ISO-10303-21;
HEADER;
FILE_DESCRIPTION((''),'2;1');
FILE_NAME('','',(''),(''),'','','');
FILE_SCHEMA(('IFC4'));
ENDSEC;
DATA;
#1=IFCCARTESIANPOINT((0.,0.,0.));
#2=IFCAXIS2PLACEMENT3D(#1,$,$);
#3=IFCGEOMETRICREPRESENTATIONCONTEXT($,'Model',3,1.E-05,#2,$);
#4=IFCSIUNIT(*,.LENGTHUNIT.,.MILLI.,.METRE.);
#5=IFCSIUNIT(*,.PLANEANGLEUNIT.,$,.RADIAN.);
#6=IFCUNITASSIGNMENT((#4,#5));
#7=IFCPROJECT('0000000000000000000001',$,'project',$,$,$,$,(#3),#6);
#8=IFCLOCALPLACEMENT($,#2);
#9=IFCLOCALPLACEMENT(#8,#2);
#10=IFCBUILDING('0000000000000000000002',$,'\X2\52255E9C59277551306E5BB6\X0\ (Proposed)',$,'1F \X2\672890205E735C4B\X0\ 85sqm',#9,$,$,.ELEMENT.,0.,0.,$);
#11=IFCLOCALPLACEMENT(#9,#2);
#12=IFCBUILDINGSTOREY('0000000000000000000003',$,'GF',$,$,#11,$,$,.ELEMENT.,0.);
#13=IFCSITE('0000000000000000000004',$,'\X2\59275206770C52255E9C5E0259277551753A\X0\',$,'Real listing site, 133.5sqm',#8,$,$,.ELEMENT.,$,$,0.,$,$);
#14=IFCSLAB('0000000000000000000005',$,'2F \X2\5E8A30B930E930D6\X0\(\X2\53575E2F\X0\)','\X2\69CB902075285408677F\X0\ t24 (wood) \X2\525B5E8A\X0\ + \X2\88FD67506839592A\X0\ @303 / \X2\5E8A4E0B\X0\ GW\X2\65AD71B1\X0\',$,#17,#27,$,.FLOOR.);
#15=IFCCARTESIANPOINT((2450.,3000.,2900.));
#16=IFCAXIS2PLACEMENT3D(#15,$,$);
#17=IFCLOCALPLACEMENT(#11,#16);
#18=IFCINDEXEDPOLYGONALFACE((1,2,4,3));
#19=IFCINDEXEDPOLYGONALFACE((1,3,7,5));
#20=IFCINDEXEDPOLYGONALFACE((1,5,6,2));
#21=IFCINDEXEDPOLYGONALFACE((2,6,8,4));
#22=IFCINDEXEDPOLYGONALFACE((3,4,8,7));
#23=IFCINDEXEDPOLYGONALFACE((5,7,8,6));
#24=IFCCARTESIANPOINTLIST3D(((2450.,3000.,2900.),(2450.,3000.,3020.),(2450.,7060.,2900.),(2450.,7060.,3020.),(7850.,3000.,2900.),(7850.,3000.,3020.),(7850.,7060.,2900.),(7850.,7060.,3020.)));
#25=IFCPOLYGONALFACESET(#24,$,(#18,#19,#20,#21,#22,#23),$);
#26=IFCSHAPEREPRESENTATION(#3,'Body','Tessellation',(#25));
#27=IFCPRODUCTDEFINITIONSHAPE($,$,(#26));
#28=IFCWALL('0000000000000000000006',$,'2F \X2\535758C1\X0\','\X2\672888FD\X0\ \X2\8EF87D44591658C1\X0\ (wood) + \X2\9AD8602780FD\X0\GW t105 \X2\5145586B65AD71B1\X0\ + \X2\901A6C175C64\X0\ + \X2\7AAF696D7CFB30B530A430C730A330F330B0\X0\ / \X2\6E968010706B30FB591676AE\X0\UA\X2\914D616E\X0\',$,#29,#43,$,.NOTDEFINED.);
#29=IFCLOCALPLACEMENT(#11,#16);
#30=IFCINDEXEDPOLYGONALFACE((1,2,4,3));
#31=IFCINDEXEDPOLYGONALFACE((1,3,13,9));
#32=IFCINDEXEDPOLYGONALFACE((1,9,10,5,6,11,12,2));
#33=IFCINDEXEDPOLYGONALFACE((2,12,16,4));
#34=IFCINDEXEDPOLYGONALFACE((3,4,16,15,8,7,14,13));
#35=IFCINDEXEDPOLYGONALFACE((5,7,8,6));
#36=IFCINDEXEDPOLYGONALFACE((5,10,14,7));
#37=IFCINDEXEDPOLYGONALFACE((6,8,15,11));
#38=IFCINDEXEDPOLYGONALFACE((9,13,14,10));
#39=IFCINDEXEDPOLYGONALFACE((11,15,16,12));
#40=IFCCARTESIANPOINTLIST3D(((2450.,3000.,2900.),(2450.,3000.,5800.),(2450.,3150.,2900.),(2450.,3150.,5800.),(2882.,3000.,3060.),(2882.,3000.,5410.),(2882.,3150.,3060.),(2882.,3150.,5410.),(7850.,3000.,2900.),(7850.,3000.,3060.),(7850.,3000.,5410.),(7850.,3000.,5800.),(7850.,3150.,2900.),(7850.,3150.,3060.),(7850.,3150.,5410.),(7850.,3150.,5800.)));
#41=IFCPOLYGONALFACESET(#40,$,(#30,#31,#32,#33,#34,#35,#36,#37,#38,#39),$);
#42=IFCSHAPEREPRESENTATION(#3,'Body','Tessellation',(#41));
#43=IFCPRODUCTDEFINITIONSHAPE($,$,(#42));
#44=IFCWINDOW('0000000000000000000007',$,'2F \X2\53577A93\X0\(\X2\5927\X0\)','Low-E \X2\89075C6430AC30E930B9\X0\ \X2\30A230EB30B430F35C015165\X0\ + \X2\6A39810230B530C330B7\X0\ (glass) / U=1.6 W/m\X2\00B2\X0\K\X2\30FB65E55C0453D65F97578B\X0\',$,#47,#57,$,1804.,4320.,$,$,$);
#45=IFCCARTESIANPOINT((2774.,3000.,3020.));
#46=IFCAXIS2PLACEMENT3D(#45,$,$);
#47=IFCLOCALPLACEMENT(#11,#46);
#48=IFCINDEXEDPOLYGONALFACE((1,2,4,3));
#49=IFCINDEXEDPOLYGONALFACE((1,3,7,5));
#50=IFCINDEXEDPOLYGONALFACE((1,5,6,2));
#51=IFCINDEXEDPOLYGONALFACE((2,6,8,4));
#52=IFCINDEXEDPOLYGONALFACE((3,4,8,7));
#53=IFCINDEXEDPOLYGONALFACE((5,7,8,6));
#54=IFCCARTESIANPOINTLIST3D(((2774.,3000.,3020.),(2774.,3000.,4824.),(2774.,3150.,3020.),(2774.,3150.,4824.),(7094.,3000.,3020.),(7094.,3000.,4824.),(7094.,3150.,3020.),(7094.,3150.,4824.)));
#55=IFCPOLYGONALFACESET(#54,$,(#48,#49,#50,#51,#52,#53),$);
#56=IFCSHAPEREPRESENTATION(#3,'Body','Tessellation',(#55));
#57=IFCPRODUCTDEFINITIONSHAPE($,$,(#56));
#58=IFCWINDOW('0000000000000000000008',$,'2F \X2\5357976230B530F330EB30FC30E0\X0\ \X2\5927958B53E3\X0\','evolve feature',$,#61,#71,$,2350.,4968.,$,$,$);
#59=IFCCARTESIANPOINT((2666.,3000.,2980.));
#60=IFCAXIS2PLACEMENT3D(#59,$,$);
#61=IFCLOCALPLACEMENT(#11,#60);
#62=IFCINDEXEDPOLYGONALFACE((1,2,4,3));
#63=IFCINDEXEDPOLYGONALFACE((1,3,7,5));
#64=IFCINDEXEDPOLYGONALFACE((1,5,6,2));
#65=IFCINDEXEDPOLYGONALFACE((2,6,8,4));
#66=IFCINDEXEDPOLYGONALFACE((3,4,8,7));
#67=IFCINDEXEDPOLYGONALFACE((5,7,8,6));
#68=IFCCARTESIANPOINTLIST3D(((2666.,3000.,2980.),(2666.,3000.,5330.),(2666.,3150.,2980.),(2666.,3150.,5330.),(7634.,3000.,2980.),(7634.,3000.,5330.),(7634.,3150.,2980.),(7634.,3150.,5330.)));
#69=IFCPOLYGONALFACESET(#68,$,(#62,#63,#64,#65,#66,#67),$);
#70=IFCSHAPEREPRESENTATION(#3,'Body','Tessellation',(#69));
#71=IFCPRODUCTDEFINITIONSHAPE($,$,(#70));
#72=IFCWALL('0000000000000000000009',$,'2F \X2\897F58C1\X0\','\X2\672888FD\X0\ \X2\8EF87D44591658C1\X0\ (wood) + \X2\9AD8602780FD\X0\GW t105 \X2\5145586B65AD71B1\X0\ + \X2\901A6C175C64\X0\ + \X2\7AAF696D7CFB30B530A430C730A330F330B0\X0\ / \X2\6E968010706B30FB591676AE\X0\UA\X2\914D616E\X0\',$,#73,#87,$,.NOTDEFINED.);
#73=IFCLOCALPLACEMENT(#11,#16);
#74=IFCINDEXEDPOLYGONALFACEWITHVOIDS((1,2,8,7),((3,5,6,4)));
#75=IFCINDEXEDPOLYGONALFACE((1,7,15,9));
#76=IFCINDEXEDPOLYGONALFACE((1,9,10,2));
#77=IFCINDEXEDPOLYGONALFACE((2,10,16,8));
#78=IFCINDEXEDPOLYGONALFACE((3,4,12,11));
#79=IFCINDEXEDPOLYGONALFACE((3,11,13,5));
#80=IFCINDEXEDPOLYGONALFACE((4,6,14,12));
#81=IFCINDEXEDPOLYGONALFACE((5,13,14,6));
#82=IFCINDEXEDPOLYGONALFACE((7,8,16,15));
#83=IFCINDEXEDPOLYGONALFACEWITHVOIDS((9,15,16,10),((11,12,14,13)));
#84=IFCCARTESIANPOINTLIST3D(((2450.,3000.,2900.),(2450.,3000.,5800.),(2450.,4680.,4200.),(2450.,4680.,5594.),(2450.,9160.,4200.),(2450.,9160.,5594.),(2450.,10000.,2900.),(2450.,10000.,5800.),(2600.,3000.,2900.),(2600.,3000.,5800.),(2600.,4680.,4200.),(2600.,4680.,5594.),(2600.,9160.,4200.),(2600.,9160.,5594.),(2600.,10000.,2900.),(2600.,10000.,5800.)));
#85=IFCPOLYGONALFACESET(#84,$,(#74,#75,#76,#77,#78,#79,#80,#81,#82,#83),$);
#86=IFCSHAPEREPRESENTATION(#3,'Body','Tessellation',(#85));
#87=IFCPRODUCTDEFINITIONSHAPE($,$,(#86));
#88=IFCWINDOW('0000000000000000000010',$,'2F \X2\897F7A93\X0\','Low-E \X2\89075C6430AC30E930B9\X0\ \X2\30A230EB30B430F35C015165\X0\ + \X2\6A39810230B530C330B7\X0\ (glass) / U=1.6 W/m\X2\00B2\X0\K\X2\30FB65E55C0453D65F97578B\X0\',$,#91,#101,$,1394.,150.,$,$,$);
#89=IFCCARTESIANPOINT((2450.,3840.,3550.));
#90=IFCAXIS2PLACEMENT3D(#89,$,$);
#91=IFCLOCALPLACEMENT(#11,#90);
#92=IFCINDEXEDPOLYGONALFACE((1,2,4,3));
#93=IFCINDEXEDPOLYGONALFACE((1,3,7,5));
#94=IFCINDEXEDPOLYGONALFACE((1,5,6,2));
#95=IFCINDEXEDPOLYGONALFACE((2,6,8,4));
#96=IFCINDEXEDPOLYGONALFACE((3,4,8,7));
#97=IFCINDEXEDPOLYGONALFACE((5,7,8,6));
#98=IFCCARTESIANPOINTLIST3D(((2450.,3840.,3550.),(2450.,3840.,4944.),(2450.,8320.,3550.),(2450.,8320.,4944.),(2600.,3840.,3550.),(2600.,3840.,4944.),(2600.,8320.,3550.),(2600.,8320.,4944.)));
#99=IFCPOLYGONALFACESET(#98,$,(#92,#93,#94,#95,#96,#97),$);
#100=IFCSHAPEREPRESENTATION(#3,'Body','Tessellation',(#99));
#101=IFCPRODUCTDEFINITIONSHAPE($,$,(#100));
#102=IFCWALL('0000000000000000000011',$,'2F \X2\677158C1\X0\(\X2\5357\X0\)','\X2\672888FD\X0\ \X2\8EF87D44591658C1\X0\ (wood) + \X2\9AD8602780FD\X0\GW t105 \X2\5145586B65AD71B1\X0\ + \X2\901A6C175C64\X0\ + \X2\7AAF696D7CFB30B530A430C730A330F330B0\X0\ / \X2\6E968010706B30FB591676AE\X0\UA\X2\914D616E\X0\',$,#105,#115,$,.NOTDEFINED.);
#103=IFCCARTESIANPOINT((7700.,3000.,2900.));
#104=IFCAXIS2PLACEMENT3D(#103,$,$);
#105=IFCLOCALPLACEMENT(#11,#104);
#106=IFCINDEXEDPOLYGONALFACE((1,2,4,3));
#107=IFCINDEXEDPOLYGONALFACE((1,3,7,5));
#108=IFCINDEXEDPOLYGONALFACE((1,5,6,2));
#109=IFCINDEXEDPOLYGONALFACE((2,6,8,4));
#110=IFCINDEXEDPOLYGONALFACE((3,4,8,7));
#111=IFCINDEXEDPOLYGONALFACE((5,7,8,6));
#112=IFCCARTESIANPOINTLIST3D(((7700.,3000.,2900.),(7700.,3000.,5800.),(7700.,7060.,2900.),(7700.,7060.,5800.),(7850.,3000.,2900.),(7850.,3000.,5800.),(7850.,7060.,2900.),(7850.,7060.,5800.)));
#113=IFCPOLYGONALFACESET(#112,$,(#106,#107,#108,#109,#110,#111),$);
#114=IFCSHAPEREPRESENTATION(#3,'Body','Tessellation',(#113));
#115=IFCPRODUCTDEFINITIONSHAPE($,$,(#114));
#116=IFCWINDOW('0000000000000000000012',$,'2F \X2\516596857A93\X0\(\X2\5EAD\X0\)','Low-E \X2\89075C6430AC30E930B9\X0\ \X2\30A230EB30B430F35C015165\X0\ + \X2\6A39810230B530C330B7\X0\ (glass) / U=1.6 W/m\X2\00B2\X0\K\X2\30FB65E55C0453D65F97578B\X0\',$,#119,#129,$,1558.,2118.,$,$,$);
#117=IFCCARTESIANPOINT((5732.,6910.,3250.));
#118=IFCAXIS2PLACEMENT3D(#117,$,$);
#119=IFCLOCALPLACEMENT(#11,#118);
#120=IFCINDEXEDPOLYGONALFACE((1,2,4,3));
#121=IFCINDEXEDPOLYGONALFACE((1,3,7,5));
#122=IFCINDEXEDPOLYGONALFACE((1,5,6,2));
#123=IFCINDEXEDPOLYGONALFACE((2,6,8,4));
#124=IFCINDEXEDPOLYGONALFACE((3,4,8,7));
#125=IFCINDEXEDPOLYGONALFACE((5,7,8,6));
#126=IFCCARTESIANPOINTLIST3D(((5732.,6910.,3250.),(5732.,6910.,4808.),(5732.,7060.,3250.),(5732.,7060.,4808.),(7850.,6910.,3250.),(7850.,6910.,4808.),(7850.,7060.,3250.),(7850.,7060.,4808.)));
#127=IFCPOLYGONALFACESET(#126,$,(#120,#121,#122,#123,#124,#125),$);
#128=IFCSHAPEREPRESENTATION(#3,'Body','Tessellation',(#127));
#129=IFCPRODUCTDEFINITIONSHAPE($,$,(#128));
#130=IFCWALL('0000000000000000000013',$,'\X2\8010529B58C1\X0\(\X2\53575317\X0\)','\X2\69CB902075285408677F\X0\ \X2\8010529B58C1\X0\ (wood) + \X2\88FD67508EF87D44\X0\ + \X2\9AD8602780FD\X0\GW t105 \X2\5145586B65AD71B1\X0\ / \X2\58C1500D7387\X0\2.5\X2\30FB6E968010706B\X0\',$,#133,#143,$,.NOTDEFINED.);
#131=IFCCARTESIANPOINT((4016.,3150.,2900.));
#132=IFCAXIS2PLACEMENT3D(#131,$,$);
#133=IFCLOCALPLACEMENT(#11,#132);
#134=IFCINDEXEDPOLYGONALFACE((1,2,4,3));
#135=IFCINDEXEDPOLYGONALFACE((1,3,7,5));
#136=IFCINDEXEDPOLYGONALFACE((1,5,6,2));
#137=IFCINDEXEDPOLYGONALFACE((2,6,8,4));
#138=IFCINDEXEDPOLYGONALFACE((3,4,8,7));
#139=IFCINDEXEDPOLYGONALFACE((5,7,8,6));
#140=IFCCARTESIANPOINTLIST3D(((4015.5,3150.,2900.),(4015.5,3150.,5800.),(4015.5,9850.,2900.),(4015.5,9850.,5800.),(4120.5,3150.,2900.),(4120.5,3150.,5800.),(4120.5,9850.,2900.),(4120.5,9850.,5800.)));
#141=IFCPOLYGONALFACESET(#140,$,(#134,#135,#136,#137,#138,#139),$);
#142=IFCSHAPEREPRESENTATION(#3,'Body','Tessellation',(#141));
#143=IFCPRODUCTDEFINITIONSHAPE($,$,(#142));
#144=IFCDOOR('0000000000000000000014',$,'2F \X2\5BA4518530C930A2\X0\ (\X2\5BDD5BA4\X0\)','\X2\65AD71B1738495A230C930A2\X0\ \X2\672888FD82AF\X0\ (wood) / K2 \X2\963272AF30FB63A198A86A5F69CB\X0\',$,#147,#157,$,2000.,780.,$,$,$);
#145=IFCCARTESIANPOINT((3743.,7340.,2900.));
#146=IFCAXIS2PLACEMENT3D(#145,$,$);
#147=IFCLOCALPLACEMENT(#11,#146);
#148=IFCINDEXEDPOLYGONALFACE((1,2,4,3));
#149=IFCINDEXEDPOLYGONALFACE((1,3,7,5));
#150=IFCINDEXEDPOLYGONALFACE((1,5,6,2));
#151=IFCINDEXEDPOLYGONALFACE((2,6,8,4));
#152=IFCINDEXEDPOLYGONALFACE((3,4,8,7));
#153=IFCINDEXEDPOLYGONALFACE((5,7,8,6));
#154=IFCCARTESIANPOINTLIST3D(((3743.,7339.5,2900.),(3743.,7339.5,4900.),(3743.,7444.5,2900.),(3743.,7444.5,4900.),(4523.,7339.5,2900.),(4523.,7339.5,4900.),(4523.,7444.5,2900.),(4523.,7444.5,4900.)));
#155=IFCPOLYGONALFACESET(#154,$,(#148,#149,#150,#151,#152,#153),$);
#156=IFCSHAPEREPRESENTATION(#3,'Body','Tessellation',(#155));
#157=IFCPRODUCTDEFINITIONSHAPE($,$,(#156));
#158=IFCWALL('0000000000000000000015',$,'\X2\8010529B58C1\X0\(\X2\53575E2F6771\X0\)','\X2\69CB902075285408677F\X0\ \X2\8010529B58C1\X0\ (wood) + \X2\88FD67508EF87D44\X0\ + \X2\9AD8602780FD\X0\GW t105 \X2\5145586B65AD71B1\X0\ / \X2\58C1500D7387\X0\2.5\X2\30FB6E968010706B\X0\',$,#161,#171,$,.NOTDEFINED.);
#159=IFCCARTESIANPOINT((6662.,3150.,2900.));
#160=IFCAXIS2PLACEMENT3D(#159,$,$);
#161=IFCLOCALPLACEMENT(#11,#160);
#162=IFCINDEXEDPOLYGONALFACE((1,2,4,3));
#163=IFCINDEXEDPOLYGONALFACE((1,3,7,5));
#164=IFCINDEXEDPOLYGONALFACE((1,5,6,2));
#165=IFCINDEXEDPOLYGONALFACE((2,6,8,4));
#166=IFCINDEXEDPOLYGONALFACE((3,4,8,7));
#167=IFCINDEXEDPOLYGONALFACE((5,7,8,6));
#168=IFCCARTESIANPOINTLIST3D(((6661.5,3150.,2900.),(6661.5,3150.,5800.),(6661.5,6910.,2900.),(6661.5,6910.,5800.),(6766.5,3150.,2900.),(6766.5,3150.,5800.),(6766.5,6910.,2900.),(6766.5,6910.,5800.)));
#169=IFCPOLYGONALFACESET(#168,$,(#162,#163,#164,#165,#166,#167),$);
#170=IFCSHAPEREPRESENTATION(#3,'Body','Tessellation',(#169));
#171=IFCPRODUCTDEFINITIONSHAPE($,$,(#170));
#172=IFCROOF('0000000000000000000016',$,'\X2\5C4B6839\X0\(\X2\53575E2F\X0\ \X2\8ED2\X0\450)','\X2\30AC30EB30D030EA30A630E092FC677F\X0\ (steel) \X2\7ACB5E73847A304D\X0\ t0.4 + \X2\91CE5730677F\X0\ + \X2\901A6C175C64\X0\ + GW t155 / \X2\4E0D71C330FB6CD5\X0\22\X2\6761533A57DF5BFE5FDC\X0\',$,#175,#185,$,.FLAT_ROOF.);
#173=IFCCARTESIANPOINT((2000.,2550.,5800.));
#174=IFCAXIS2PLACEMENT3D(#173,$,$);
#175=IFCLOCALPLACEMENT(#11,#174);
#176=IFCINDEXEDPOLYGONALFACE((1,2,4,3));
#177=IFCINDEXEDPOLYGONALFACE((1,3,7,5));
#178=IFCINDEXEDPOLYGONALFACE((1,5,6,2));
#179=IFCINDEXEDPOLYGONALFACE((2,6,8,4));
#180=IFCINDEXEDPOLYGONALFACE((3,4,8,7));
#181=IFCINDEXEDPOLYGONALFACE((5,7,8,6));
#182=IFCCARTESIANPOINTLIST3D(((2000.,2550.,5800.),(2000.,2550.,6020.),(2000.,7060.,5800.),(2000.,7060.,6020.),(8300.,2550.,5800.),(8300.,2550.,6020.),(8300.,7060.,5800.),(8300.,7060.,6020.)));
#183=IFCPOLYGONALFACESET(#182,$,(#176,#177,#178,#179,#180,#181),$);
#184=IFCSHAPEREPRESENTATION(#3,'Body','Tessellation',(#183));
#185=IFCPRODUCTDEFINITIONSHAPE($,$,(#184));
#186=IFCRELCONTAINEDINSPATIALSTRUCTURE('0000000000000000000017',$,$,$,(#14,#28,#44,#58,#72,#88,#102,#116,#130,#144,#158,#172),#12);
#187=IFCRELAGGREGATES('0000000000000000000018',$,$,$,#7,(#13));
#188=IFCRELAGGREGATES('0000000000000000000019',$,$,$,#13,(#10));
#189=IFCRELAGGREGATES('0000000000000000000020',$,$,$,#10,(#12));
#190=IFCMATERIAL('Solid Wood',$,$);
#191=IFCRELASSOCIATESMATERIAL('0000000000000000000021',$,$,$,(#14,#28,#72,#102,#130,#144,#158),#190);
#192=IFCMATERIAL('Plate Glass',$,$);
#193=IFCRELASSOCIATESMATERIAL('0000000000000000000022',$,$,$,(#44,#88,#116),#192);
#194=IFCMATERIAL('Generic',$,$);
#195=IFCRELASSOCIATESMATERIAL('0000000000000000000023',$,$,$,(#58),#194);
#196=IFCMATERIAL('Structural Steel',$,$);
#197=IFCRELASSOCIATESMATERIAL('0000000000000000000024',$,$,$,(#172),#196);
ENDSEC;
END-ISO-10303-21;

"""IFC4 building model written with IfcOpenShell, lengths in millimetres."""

from ifc_helpers import new_model, si_unit, frame, frame_2d, origin, place, context, project, spatial, rectangle, extrude, material, element, fill, save


model = new_model("IFC4")

# Units and contexts
model_context = context("Model", 3, precision=1e-05, world=origin())
ifc_project = project(units=[si_unit("LENGTHUNIT", "METRE", prefix="MILLI"), si_unit("PLANEANGLEUNIT", "RADIAN")], contexts=[model_context])

# Site, building, storey
site_placement = place(None, origin())
site = spatial("IfcSite", under=ifc_project, at=site_placement, Name="大分県別府市大畑町", ObjectType="Real listing site, 133.5sqm", CompositionType="ELEMENT", RefElevation=0.0)
building_placement = place(site_placement, origin())
building = spatial("IfcBuilding", under=site, at=building_placement, Name="別府大畑の家 (Proposed)", ObjectType="1F 木造平屋 85sqm", CompositionType="ELEMENT", ElevationOfRefHeight=0.0, ElevationOfTerrain=0.0)
storey_placement = place(building_placement, origin())
storey = spatial("IfcBuildingStorey", under=building, at=storey_placement, Name="GF", CompositionType="ELEMENT", Elevation=0.0)

# Slab
ifc_material_1 = material(Name="Solid Wood")
slab_placement = place(storey_placement, frame((2450.0, 3000.0, 2900.0)))
element("IfcSlab", 1, at=slab_placement, inside=storey, material=ifc_material_1, Name="2F 床スラブ(南帯)", Description="構造用合板 t24 (wood) 剛床 + 製材根太 @303 / 床下 GW断熱", PredefinedType="FLOOR", context=model_context, shape_type="SweptSolid", body=[
    extrude(rectangle(XDim=5400.0, YDim=4060.0, at=frame_2d((2700.0, 2030.0))), frame((2450.0, 3000.0, 2900.0)), (0.0, 0.0, 1.0), 120.0),
])

# Wall, openings, windows
wall_1_placement = place(storey_placement, frame((2450.0, 3000.0, 2900.0)))
wall_1 = element("IfcWall", 2, at=wall_1_placement, inside=storey, material=ifc_material_1, Name="2F 南壁", Description="木製 軸組外壁 (wood) + 高性能GW t105 充填断熱 + 通気層 + 窯業系サイディング / 準耐火・外皮UA配慮", PredefinedType="NOTDEFINED", context=model_context, shape_type="SweptSolid", body=[
    extrude(rectangle(XDim=5400.0, YDim=150.0, at=frame_2d((2700.0, 75.0))), frame((2450.0, 3000.0, 2900.0)), (0.0, 0.0, 1.0), 2900.0),
])
opening_1_placement = place(storey_placement, frame((2774.0, 3000.0, 3020.0)))
opening_1 = element("IfcOpeningElement", 3, at=opening_1_placement, cuts=wall_1, PredefinedType="NOTDEFINED", context=model_context, shape_type="SweptSolid", body=[
    extrude(rectangle(XDim=4320.0, YDim=150.0, at=frame_2d((2160.0, 75.0))), frame((2774.0, 3000.0, 3020.0)), (0.0, 0.0, 1.0), 1804.0),
])
opening_2_placement = place(storey_placement, frame((2666.0, 3000.0, 2980.0)))
opening_2 = element("IfcOpeningElement", 4, at=opening_2_placement, cuts=wall_1, PredefinedType="NOTDEFINED", context=model_context, shape_type="SweptSolid", body=[
    extrude(rectangle(XDim=4968.0, YDim=150.0, at=frame_2d((2484.0, 75.0))), frame((2666.0, 3000.0, 2980.0)), (0.0, 0.0, 1.0), 2350.0),
])
ifc_material_2 = material(Name="Plate Glass")
window_1_placement = place(storey_placement, frame((2774.0, 3000.0, 3020.0)))
window_1 = element("IfcWindow", 5, at=window_1_placement, inside=storey, material=ifc_material_2, Name="2F 南窓(大)", Description="Low-E 複層ガラス アルゴン封入 + 樹脂サッシ (glass) / U=1.6 W/m²K・日射取得型", OverallHeight=1804.0, OverallWidth=4320.0, context=model_context, shape_type="SweptSolid", body=[
    extrude(rectangle(XDim=4320.0, YDim=150.0, at=frame_2d((2160.0, 75.0))), frame((2774.0, 3000.0, 3020.0)), (0.0, 0.0, 1.0), 1804.0),
])
fill(opening_1, window_1)
ifc_material_3 = material(Name="Generic")
window_2_placement = place(storey_placement, frame((2666.0, 3000.0, 2980.0)))
window_2 = element("IfcWindow", 6, at=window_2_placement, inside=storey, material=ifc_material_3, Name="2F 南面サンルーム 大開口", Description="evolve feature", OverallHeight=2350.0, OverallWidth=4968.0, context=model_context, shape_type="SweptSolid", body=[
    extrude(rectangle(XDim=4968.0, YDim=150.0, at=frame_2d((2484.0, 75.0))), frame((2666.0, 3000.0, 2980.0)), (0.0, 0.0, 1.0), 2350.0),
])
fill(opening_2, window_2)

# Walls, openings, windows
wall_2_placement = place(storey_placement, frame((2450.0, 3000.0, 2900.0)))
wall_2 = element("IfcWall", 7, at=wall_2_placement, inside=storey, material=ifc_material_1, Name="2F 西壁", Description="木製 軸組外壁 (wood) + 高性能GW t105 充填断熱 + 通気層 + 窯業系サイディング / 準耐火・外皮UA配慮", PredefinedType="NOTDEFINED", context=model_context, shape_type="SweptSolid", body=[
    extrude(rectangle(XDim=150.0, YDim=7000.0, at=frame_2d((75.0, 3500.0))), frame((2450.0, 3000.0, 2900.0)), (0.0, 0.0, 1.0), 2900.0),
])
opening_3_placement = place(storey_placement, frame((2450.0, 3840.0, 3550.0)))
opening_3 = element("IfcOpeningElement", 8, at=opening_3_placement, cuts=wall_2, PredefinedType="NOTDEFINED", context=model_context, shape_type="SweptSolid", body=[
    extrude(rectangle(XDim=150.0, YDim=4480.0, at=frame_2d((75.0, 2240.0))), frame((2450.0, 3840.0, 3550.0)), (0.0, 0.0, 1.0), 1394.0),
])
window_3_placement = place(storey_placement, frame((2450.0, 3840.0, 3550.0)))
window_3 = element("IfcWindow", 9, at=window_3_placement, inside=storey, material=ifc_material_2, Name="2F 西窓", Description="Low-E 複層ガラス アルゴン封入 + 樹脂サッシ (glass) / U=1.6 W/m²K・日射取得型", OverallHeight=1394.0, OverallWidth=150.0, context=model_context, shape_type="SweptSolid", body=[
    extrude(rectangle(XDim=150.0, YDim=4480.0, at=frame_2d((75.0, 2240.0))), frame((2450.0, 3840.0, 3550.0)), (0.0, 0.0, 1.0), 1394.0),
])
fill(opening_3, window_3)
wall_3_placement = place(storey_placement, frame((7700.0, 3000.0, 2900.0)))
wall_3 = element("IfcWall", 10, at=wall_3_placement, inside=storey, material=ifc_material_1, Name="2F 東壁(南)", Description="木製 軸組外壁 (wood) + 高性能GW t105 充填断熱 + 通気層 + 窯業系サイディング / 準耐火・外皮UA配慮", PredefinedType="NOTDEFINED", context=model_context, shape_type="SweptSolid", body=[
    extrude(rectangle(XDim=150.0, YDim=4060.0, at=frame_2d((75.0, 2030.0))), frame((7700.0, 3000.0, 2900.0)), (0.0, 0.0, 1.0), 2900.0),
])
opening_4_placement = place(storey_placement, frame((5732.0, 6910.0, 3250.0)))
opening_4 = element("IfcOpeningElement", 11, at=opening_4_placement, cuts=wall_3, PredefinedType="NOTDEFINED", context=model_context, shape_type="SweptSolid", body=[
    extrude(rectangle(XDim=2118.0, YDim=150.0, at=frame_2d((1059.0, 75.0))), frame((5732.0, 6910.0, 3250.0)), (0.0, 0.0, 1.0), 1558.0),
])
window_4_placement = place(storey_placement, frame((5732.0, 6910.0, 3250.0)))
window_4 = element("IfcWindow", 12, at=window_4_placement, inside=storey, material=ifc_material_2, Name="2F 入隅窓(庭)", Description="Low-E 複層ガラス アルゴン封入 + 樹脂サッシ (glass) / U=1.6 W/m²K・日射取得型", OverallHeight=1558.0, OverallWidth=2118.0, context=model_context, shape_type="SweptSolid", body=[
    extrude(rectangle(XDim=2118.0, YDim=150.0, at=frame_2d((1059.0, 75.0))), frame((5732.0, 6910.0, 3250.0)), (0.0, 0.0, 1.0), 1558.0),
])
fill(opening_4, window_4)

# Wall, opening, door
wall_4_placement = place(storey_placement, frame((4016.0, 3150.0, 2900.0)))
wall_4 = element("IfcWall", 13, at=wall_4_placement, inside=storey, material=ifc_material_1, Name="耐力壁(南北)", Description="構造用合板 耐力壁 (wood) + 製材軸組 + 高性能GW t105 充填断熱 / 壁倍率2.5・準耐火", PredefinedType="NOTDEFINED", context=model_context, shape_type="SweptSolid", body=[
    extrude(rectangle(XDim=105.0, YDim=6700.0, at=frame_2d((52.0, 3350.0))), frame((4016.0, 3150.0, 2900.0)), (0.0, 0.0, 1.0), 2900.0),
])
opening_5_placement = place(storey_placement, frame((3743.0, 7340.0, 2900.0)))
opening_5 = element("IfcOpeningElement", 14, at=opening_5_placement, cuts=wall_4, PredefinedType="NOTDEFINED", context=model_context, shape_type="SweptSolid", body=[
    extrude(rectangle(XDim=780.0, YDim=105.0, at=frame_2d((390.0, 52.0))), frame((3743.0, 7340.0, 2900.0)), (0.0, 0.0, 1.0), 2000.0),
])
door_placement = place(storey_placement, frame((3743.0, 7340.0, 2900.0)))
door = element("IfcDoor", 15, at=door_placement, inside=storey, material=ifc_material_1, Name="2F 室内ドア (寝室)", Description="断熱玄関ドア 木製芯 (wood) / K2 防犯・採風機構", OverallHeight=2000.0, OverallWidth=780.0, context=model_context, shape_type="SweptSolid", body=[
    extrude(rectangle(XDim=780.0, YDim=105.0, at=frame_2d((390.0, 52.0))), frame((3743.0, 7340.0, 2900.0)), (0.0, 0.0, 1.0), 2000.0),
])
fill(opening_5, door)

# Wall
wall_5_placement = place(storey_placement, frame((6662.0, 3150.0, 2900.0)))
element("IfcWall", 16, at=wall_5_placement, inside=storey, material=ifc_material_1, Name="耐力壁(南帯東)", Description="構造用合板 耐力壁 (wood) + 製材軸組 + 高性能GW t105 充填断熱 / 壁倍率2.5・準耐火", PredefinedType="NOTDEFINED", context=model_context, shape_type="SweptSolid", body=[
    extrude(rectangle(XDim=105.0, YDim=3760.0, at=frame_2d((52.0, 1880.0))), frame((6662.0, 3150.0, 2900.0)), (0.0, 0.0, 1.0), 2900.0),
])

# Roof
ifc_material_4 = material(Name="Structural Steel")
for number, where, name in (
    (17, (2000.0, 2550.0, 5800.0), "屋根(南帯 軒450)"),
):
    element("IfcRoof", number, at=place(storey_placement, frame(where)), inside=storey, material=ifc_material_4, Name=name, Description="ガルバリウム鋼板 (steel) 立平葺き t0.4 + 野地板 + 通気層 + GW t155 / 不燃・法22条区域対応", PredefinedType="FLAT_ROOF", context=model_context, shape_type="SweptSolid", body=[
        extrude(rectangle(XDim=6300.0, YDim=4510.0, at=frame_2d((3150.0, 2255.0))), frame((2000.0, 2550.0, 5800.0)), (0.0, 0.0, 1.0), 220.0),
    ])

save(model, "model.ifc")
